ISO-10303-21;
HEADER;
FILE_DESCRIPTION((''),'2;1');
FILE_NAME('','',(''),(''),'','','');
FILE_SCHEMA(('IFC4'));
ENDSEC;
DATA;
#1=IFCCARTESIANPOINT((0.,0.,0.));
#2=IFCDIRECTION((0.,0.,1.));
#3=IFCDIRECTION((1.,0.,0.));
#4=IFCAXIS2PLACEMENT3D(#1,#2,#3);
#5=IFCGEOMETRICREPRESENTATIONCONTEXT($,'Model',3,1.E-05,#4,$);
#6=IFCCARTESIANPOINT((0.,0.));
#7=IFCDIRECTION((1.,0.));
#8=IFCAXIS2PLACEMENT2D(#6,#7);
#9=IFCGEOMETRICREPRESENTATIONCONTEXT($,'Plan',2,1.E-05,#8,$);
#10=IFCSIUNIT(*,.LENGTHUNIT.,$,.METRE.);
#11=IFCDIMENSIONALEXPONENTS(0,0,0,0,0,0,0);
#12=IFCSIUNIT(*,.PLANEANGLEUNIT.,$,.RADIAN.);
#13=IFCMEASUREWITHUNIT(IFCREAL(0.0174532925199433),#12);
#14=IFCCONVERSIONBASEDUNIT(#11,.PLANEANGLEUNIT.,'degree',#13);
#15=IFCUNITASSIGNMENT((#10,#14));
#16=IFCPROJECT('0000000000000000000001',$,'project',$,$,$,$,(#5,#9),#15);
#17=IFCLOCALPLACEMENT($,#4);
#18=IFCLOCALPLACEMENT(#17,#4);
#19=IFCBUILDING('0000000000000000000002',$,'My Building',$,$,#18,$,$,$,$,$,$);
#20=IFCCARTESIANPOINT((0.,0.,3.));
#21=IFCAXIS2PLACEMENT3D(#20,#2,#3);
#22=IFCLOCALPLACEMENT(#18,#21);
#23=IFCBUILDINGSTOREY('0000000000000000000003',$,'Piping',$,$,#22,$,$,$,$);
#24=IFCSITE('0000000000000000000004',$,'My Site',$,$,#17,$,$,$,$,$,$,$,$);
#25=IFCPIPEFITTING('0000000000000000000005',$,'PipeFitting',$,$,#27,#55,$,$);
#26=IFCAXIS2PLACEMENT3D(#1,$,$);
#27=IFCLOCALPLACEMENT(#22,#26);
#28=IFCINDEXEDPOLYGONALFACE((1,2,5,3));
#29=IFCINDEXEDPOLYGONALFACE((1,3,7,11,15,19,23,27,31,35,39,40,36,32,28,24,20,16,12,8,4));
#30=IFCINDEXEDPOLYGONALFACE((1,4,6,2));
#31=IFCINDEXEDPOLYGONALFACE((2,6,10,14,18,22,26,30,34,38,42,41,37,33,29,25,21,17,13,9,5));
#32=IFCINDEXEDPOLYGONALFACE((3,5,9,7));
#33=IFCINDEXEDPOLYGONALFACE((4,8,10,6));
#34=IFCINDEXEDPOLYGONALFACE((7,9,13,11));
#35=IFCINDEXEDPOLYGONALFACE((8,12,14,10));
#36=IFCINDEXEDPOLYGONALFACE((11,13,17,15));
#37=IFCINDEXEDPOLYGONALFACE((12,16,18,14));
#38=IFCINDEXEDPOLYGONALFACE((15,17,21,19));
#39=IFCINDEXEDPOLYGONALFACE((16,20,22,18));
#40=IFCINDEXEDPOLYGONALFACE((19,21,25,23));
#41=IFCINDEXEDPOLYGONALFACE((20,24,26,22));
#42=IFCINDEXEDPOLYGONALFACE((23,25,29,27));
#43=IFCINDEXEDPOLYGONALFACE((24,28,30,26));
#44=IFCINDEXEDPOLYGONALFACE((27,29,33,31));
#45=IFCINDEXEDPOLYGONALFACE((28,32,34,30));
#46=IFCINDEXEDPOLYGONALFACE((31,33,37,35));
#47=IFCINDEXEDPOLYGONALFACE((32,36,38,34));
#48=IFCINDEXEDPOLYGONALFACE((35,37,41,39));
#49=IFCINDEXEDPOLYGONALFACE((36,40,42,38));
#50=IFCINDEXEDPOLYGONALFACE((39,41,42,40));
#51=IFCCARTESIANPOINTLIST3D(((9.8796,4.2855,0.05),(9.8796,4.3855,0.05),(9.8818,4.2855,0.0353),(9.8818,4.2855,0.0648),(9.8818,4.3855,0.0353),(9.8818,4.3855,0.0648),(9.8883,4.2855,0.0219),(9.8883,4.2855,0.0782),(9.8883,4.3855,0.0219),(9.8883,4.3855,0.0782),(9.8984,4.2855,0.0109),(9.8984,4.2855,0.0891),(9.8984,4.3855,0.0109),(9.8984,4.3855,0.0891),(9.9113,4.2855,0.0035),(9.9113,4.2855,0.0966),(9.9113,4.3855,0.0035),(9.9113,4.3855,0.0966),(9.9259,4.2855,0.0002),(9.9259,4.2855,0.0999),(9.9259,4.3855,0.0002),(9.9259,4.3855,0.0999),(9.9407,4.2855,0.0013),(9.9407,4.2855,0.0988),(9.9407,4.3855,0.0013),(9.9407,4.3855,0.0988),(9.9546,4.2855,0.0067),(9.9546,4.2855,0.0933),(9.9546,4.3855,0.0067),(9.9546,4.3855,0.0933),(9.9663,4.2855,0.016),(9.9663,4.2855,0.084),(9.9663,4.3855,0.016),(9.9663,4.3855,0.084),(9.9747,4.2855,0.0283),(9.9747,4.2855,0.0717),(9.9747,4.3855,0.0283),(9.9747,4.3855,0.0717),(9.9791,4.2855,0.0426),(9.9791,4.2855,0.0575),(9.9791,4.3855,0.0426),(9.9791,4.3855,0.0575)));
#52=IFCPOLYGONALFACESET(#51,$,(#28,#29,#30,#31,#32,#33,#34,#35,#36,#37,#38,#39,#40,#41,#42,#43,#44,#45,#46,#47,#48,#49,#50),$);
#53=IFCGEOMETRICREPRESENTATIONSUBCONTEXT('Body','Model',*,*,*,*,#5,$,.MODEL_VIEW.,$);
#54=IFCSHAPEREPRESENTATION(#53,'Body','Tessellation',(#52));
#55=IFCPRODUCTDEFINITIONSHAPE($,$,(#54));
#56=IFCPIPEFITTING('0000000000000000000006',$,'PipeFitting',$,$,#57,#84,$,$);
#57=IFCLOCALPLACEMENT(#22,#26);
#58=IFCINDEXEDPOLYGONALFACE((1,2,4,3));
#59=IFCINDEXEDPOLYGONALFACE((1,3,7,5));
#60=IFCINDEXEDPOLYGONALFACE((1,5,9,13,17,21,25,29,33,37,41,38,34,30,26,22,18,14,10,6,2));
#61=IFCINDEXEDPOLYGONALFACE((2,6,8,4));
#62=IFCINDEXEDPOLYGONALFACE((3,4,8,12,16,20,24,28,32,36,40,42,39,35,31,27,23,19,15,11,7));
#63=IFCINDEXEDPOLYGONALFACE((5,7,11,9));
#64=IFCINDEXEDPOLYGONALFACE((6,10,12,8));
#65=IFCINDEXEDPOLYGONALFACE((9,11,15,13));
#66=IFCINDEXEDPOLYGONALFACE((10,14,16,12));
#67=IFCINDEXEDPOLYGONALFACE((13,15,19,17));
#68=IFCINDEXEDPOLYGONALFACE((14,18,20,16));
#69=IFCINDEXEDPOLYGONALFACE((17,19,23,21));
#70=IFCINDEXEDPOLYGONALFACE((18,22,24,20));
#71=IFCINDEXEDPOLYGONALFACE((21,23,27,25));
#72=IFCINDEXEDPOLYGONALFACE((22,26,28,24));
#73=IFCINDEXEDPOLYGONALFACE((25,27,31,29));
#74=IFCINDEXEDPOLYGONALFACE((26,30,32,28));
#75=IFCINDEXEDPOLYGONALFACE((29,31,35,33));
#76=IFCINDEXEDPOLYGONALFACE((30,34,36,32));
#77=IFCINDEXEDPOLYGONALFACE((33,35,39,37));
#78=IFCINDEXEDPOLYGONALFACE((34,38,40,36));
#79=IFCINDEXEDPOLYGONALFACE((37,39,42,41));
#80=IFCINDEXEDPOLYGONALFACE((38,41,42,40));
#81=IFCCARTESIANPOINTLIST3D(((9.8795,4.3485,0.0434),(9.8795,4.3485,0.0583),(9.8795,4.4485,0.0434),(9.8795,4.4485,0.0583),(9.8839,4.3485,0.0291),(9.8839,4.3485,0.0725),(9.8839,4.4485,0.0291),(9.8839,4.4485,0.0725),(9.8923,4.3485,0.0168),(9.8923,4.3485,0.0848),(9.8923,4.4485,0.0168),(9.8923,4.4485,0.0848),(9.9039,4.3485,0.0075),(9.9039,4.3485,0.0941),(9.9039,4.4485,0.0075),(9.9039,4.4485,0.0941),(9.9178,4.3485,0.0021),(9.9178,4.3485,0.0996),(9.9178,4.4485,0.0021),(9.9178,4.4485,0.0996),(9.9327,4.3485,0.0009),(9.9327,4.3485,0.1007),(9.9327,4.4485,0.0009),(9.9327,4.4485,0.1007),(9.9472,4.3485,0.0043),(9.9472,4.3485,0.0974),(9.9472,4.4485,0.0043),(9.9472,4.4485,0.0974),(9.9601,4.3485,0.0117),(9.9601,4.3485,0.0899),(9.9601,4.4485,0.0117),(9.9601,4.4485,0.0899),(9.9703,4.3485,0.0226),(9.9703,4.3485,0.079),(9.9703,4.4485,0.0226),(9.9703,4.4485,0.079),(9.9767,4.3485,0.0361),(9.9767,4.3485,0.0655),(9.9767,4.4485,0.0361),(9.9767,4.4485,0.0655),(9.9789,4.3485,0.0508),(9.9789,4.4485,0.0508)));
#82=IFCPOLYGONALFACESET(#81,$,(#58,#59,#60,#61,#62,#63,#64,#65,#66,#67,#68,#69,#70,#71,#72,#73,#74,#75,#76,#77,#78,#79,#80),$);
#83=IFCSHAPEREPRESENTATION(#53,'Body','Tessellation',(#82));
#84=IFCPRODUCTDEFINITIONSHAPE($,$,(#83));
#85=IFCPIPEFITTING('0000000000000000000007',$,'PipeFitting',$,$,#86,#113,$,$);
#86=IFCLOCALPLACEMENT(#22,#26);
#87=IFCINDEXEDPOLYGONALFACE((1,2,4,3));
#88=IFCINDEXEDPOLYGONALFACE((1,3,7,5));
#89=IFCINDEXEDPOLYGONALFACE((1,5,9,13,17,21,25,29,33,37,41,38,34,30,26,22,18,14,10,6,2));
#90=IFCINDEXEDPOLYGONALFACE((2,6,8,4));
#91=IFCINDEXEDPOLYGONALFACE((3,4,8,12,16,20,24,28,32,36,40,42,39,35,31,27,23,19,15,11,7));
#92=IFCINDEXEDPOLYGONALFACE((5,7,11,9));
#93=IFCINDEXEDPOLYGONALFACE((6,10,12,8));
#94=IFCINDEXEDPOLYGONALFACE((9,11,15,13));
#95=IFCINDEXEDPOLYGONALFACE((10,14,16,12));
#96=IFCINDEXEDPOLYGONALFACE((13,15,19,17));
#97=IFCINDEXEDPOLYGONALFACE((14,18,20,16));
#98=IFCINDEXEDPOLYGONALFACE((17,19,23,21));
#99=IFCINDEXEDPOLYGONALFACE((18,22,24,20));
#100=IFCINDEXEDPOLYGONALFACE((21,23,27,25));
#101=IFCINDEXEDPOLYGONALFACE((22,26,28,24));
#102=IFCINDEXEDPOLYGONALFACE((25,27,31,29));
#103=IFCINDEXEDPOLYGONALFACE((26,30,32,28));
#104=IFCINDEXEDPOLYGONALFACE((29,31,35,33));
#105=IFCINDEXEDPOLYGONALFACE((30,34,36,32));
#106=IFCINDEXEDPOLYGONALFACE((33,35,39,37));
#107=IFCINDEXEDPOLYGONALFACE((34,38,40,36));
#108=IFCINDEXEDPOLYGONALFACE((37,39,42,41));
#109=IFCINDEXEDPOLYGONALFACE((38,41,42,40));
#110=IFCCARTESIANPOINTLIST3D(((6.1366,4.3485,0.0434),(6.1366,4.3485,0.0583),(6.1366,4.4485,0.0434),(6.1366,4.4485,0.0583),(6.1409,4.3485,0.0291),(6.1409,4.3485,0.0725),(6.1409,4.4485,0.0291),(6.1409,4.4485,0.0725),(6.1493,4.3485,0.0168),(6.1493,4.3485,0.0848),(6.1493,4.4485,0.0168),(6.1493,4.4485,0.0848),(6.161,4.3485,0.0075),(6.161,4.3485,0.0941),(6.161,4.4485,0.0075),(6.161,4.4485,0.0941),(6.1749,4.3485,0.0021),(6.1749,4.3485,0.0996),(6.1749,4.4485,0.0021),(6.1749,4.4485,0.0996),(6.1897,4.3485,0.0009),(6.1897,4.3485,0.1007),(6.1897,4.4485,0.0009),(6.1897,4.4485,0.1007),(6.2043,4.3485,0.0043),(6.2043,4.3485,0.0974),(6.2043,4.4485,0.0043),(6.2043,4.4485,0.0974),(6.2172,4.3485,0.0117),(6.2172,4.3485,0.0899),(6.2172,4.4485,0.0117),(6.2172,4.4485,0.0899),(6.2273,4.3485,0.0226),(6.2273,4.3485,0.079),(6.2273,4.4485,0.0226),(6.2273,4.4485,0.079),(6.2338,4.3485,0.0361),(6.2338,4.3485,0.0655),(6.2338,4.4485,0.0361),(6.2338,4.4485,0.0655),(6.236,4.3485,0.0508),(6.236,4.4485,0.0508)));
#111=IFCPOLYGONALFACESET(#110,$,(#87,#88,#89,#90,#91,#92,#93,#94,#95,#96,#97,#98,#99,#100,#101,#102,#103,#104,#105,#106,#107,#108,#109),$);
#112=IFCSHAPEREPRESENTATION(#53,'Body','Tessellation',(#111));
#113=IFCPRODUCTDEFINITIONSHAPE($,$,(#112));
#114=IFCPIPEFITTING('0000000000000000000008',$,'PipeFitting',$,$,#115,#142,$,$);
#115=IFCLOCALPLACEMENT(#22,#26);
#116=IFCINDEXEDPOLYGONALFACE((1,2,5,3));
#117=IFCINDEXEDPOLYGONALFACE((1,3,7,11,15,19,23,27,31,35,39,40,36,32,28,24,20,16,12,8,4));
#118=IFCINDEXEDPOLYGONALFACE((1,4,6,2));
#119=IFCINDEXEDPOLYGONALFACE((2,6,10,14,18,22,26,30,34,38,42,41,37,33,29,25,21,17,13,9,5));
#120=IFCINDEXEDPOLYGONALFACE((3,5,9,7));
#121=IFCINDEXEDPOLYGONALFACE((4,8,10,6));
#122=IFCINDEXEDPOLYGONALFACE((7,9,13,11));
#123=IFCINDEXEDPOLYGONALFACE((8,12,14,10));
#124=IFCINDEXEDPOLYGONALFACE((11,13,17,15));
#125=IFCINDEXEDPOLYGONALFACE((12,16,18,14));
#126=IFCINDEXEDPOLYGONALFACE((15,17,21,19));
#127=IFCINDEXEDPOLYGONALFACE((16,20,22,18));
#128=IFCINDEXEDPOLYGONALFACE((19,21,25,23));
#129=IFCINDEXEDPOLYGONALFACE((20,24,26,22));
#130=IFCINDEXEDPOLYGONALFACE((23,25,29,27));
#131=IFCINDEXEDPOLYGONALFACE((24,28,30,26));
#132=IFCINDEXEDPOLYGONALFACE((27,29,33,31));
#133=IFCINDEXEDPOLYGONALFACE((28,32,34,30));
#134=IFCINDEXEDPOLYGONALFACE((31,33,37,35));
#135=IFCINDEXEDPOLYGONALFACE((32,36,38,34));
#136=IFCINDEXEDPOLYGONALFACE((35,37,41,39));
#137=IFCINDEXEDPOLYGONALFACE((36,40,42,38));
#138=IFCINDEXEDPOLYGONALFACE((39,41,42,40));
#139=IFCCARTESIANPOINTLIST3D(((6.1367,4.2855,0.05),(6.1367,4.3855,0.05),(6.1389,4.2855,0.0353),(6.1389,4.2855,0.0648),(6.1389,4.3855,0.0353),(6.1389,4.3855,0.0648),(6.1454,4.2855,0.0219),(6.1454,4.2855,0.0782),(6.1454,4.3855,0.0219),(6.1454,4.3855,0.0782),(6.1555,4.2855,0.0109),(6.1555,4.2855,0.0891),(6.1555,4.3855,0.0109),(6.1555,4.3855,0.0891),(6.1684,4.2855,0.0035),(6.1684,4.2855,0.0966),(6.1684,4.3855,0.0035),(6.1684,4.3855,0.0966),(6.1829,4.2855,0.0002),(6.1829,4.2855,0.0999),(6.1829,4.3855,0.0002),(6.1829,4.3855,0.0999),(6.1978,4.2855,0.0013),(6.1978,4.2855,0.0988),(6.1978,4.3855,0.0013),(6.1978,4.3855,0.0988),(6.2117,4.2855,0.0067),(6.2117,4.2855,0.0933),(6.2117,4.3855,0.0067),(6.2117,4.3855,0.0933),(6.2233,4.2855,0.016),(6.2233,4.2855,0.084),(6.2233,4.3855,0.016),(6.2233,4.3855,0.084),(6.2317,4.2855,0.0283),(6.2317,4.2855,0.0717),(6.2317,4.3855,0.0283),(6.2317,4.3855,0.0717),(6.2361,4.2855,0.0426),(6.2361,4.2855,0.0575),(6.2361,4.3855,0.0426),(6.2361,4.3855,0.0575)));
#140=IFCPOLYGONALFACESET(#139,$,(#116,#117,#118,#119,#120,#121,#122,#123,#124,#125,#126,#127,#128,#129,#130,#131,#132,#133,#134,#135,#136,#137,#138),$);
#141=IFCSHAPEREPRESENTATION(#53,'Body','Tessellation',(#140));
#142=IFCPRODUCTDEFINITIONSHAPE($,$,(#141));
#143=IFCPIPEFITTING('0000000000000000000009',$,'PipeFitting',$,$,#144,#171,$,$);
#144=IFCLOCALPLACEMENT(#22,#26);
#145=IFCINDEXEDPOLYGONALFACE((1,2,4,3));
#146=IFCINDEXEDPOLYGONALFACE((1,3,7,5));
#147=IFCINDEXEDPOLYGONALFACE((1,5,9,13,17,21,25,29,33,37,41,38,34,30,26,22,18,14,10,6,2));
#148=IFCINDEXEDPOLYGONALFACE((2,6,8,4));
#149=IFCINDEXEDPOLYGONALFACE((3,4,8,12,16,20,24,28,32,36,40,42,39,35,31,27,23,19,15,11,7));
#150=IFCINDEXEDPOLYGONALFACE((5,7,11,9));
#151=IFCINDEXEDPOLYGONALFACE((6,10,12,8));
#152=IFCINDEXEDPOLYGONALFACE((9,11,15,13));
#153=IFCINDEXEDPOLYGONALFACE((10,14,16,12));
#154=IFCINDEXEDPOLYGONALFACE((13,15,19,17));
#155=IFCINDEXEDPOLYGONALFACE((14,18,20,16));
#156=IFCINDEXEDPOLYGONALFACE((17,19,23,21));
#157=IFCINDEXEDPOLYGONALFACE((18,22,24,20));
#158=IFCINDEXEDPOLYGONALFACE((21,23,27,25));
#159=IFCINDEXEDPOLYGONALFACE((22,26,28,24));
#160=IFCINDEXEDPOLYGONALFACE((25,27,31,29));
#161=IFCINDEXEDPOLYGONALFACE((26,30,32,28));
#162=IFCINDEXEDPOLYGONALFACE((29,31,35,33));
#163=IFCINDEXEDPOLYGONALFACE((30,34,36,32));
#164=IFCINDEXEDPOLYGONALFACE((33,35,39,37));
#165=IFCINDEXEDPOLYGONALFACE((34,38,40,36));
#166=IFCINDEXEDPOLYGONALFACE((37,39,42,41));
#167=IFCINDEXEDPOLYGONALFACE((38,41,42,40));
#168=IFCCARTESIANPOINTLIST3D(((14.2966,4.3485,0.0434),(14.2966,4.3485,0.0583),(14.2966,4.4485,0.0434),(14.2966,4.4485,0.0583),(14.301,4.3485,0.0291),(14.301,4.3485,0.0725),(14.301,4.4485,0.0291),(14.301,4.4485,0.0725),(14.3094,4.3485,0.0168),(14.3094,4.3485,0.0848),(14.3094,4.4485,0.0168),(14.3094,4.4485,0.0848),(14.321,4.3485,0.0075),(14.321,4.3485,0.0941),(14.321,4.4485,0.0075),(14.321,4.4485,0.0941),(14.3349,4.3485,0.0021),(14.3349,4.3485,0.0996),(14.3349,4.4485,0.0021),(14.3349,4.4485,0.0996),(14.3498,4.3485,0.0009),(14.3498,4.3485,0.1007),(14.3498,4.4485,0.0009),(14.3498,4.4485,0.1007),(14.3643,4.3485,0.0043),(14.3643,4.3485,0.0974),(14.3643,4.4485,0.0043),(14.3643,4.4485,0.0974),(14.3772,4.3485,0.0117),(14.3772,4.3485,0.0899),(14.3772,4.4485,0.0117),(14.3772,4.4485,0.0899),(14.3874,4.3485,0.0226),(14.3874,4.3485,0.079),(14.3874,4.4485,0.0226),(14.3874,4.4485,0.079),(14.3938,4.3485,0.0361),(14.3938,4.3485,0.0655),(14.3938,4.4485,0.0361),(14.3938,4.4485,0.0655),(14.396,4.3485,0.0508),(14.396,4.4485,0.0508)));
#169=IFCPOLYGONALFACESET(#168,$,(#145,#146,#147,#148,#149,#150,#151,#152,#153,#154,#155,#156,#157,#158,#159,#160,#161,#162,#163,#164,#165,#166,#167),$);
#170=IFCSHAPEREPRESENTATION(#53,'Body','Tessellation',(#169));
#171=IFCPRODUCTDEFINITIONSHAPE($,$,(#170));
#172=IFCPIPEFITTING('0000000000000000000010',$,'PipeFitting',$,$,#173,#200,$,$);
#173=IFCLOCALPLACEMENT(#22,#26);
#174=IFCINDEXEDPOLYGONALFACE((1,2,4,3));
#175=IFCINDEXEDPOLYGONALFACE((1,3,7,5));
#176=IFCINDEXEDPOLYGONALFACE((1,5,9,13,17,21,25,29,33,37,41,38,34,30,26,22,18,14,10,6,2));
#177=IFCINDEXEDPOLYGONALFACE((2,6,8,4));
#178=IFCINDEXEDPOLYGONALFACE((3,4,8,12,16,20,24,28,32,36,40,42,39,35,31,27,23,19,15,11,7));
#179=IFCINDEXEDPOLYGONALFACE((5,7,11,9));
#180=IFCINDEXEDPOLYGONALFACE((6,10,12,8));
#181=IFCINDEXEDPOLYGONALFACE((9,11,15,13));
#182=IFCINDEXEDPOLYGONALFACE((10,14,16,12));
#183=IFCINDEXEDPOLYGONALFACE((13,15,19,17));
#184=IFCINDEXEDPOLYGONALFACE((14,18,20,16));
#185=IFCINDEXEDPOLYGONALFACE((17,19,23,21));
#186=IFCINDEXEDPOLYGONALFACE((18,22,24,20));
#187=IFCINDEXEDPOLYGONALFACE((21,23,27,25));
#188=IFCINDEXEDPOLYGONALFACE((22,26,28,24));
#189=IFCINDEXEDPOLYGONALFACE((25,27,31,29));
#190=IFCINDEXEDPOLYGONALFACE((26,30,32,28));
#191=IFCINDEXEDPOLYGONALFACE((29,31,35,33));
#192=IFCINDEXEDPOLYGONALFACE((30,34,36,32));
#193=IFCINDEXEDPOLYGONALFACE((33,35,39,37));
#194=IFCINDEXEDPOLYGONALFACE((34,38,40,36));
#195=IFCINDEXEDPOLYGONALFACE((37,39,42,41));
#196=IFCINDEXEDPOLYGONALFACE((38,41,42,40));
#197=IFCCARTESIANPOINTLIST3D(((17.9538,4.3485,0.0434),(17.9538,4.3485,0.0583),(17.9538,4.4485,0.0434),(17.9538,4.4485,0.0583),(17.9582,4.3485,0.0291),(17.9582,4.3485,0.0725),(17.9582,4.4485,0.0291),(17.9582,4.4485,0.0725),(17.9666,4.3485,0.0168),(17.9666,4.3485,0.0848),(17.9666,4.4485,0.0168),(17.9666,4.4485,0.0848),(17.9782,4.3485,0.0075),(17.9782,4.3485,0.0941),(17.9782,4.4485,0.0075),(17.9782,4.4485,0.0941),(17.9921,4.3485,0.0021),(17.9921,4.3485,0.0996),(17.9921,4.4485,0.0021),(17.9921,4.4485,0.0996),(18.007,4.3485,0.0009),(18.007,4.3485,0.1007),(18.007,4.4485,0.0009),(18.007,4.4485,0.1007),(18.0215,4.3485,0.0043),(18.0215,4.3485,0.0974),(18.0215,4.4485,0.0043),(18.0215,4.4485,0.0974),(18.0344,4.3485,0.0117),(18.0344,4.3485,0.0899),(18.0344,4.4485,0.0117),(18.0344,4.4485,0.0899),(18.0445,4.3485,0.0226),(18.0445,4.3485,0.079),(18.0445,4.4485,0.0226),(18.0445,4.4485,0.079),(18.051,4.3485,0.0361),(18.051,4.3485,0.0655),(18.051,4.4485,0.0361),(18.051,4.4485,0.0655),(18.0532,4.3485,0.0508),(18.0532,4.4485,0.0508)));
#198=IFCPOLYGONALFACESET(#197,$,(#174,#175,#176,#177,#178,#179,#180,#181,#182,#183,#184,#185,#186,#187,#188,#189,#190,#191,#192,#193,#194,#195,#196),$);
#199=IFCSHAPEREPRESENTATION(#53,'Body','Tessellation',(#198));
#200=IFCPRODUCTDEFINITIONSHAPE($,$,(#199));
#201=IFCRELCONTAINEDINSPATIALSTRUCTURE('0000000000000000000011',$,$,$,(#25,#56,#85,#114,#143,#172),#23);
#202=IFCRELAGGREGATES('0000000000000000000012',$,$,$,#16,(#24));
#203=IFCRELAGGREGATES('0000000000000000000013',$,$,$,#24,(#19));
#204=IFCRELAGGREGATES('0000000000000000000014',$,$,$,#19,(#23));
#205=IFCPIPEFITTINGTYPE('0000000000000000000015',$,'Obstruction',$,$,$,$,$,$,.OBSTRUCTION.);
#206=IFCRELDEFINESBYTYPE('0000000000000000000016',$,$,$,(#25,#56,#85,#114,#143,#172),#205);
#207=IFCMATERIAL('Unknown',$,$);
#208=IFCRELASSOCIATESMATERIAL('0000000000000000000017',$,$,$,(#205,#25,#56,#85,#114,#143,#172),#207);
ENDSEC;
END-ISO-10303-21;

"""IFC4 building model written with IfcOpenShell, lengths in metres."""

from ifc_helpers import new_model, entity, si_unit, converted_unit, frame, origin_with_axes, origin_2d_with_axis, place, context, subcontext, project, spatial, circle, extrude, material, material_profile, profile_set, profile_usage, type_object, element, save


model = new_model("IFC4")

# Units and contexts
model_context = context("Model", 3, precision=1e-05, world=origin_with_axes())
plan_context = context("Plan", 2, precision=1e-05, world=origin_2d_with_axis())
body_context = subcontext(model_context, "Body", "Model", "MODEL_VIEW")
ifc_project = project(units=[si_unit("LENGTHUNIT", "METRE"), converted_unit("PLANEANGLEUNIT", "degree", entity("IfcReal", 0.0174532925199433), si_unit("PLANEANGLEUNIT", "RADIAN"), dimensions=[0, 0, 0, 0, 0, 0, 0])], contexts=[model_context, plan_context])

# Site, building, storey
site_placement = place(None, origin_with_axes())
site = spatial("IfcSite", under=ifc_project, at=site_placement, Name="My Site")
building_placement = place(site_placement, origin_with_axes())
building = spatial("IfcBuilding", under=site, at=building_placement, Name="My Building")
storey_placement = place(building_placement, frame((0.0, 0.0, 3.0), z_axis=(0.0, 0.0, 1.0), x_axis=(1.0, 0.0, 0.0)))
storey = spatial("IfcBuildingStorey", under=building, at=storey_placement, Name="Piping")

# Shared definitions
ifc_material = material(Name="Unknown")

# Pipe fittings
ifc_material_profile_1 = material_profile(ifc_material, circle(Radius=0.05))
ifc_profile_set_1 = profile_set([ifc_material_profile_1])
ifc_profile_usage_1 = profile_usage(ifc_profile_set_1, cardinal=5)
pipe_fitting_type = type_object("IfcPipeFittingType", Name="Obstruction", PredefinedType="OBSTRUCTION", material=ifc_profile_set_1)
pipe_fitting_1_placement = place(storey_placement, frame((9.9296, 4.2855, 0.05), z_axis=(0.0, 1.0, 0.0), x_axis=(-1.0, 0.0, 0.0)))
element("IfcPipeFitting", 1, at=pipe_fitting_1_placement, inside=storey, type_object=pipe_fitting_type, material=ifc_profile_usage_1, Name="PipeFitting", context=body_context, shape_type="SweptSolid", body=[
    extrude(circle(Radius=0.05), origin_with_axes(), (0.0, 0.0, 1.0), 0.1),
])
ifc_profile_usage_2 = profile_usage(ifc_profile_set_1, cardinal=5)
pipe_fitting_2_placement = place(storey_placement, frame((9.9289, 4.3485, 0.0508), z_axis=(0.0, 1.0, 0.0), x_axis=(1.0, 0.0, 0.0)))
element("IfcPipeFitting", 2, at=pipe_fitting_2_placement, inside=storey, type_object=pipe_fitting_type, material=ifc_profile_usage_2, Name="PipeFitting", context=body_context, shape_type="SweptSolid", body=[
    extrude(circle(Radius=0.05), origin_with_axes(), (0.0, 0.0, 1.0), 0.1),
])
ifc_profile_usage_3 = profile_usage(ifc_profile_set_1, cardinal=5)
pipe_fitting_3_placement = place(storey_placement, frame((6.186, 4.3485, 0.0508), z_axis=(0.0, 1.0, 0.0), x_axis=(1.0, 0.0, 0.0)))
element("IfcPipeFitting", 3, at=pipe_fitting_3_placement, inside=storey, type_object=pipe_fitting_type, material=ifc_profile_usage_3, Name="PipeFitting", context=body_context, shape_type="SweptSolid", body=[
    extrude(circle(Radius=0.05), origin_with_axes(), (0.0, 0.0, 1.0), 0.1),
])
ifc_profile_usage_4 = profile_usage(ifc_profile_set_1, cardinal=5)
pipe_fitting_4_placement = place(storey_placement, frame((6.1867, 4.2855, 0.05), z_axis=(0.0, 1.0, 0.0), x_axis=(-1.0, 0.0, 0.0)))
element("IfcPipeFitting", 4, at=pipe_fitting_4_placement, inside=storey, type_object=pipe_fitting_type, material=ifc_profile_usage_4, Name="PipeFitting", context=body_context, shape_type="SweptSolid", body=[
    extrude(circle(Radius=0.05), origin_with_axes(), (0.0, 0.0, 1.0), 0.1),
])
ifc_profile_usage_5 = profile_usage(ifc_profile_set_1, cardinal=5)
pipe_fitting_5_placement = place(storey_placement, frame((14.346, 4.3485, 0.0508), z_axis=(0.0, 1.0, 0.0), x_axis=(1.0, 0.0, 0.0)))
element("IfcPipeFitting", 5, at=pipe_fitting_5_placement, inside=storey, type_object=pipe_fitting_type, material=ifc_profile_usage_5, Name="PipeFitting", context=body_context, shape_type="SweptSolid", body=[
    extrude(circle(Radius=0.05), origin_with_axes(), (0.0, 0.0, 1.0), 0.1),
])
ifc_profile_usage_6 = profile_usage(ifc_profile_set_1, cardinal=5)
pipe_fitting_6_placement = place(storey_placement, frame((18.0032, 4.3485, 0.0508), z_axis=(0.0, 1.0, 0.0), x_axis=(1.0, 0.0, 0.0)))
element("IfcPipeFitting", 6, at=pipe_fitting_6_placement, inside=storey, type_object=pipe_fitting_type, material=ifc_profile_usage_6, Name="PipeFitting", context=body_context, shape_type="SweptSolid", body=[
    extrude(circle(Radius=0.05), origin_with_axes(), (0.0, 0.0, 1.0), 0.1),
])

save(model, "model.ifc")
